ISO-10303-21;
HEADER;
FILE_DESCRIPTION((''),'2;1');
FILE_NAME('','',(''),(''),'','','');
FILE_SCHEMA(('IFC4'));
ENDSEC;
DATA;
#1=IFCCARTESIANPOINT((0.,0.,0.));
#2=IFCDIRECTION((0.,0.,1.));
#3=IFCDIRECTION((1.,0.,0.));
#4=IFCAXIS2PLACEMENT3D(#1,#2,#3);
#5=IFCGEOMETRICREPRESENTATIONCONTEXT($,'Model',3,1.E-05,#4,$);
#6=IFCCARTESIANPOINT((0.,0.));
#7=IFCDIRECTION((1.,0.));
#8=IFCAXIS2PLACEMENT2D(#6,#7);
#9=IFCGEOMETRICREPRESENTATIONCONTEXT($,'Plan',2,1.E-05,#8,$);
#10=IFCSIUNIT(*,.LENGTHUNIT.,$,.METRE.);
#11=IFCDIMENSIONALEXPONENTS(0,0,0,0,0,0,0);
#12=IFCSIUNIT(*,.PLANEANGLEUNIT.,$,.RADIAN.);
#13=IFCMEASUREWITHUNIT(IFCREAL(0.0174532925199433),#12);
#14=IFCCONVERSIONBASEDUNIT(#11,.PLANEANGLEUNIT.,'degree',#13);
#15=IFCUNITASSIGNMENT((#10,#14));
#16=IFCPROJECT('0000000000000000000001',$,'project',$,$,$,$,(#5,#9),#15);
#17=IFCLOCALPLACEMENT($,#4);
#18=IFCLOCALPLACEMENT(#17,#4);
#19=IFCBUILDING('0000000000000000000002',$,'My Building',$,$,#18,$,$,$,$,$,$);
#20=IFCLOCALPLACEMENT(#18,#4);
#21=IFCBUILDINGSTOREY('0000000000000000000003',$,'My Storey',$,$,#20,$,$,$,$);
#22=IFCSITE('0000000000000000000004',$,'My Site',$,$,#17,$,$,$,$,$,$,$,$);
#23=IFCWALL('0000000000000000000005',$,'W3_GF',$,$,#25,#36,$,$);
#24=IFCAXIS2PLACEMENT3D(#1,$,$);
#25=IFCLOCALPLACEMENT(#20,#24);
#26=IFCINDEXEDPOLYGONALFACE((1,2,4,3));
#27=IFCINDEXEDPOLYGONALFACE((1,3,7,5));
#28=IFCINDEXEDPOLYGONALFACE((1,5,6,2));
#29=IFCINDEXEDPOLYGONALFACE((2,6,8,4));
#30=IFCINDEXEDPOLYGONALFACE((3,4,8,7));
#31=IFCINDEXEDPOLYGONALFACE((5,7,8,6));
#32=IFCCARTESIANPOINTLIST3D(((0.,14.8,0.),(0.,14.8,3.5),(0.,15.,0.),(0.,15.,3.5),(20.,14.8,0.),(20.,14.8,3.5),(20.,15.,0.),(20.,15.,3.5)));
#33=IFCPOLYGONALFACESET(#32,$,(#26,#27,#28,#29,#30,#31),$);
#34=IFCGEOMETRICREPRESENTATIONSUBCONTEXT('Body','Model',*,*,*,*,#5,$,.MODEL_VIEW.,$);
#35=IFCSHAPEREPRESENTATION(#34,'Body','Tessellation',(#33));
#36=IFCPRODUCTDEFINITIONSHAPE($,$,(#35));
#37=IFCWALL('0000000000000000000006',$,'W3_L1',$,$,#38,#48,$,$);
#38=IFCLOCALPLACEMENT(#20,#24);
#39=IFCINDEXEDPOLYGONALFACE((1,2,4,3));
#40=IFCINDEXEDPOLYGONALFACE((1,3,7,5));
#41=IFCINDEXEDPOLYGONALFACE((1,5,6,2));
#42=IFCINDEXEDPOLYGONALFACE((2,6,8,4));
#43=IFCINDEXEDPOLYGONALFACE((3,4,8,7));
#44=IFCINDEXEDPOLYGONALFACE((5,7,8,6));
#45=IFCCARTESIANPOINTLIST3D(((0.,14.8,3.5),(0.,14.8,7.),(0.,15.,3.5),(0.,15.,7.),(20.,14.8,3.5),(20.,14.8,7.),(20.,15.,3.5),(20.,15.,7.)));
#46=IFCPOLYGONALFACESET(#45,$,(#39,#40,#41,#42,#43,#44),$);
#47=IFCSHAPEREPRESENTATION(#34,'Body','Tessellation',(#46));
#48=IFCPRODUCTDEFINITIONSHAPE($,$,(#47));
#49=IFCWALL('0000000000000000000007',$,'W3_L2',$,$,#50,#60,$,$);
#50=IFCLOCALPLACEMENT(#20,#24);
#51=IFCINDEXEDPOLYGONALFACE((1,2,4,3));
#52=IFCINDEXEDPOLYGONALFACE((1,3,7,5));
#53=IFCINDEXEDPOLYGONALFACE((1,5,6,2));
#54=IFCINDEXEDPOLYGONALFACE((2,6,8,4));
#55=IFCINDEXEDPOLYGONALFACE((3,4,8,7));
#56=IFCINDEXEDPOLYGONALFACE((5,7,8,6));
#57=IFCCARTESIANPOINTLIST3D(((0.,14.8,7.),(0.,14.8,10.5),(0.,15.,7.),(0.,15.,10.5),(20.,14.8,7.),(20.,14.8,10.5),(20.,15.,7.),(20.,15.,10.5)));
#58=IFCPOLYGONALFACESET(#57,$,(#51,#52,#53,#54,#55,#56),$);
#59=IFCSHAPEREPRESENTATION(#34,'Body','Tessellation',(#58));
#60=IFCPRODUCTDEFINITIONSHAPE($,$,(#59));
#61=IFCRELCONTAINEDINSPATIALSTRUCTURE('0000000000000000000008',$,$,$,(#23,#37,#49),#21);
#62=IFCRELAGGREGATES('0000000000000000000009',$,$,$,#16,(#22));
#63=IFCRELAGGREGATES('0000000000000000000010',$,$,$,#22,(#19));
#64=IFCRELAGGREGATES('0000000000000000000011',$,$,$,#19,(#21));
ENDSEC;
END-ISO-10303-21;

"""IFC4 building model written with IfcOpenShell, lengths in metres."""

from ifc_helpers import new_model, entity, si_unit, converted_unit, frame, origin_with_axes, origin_2d_with_axis, place, context, subcontext, project, spatial, indexed_curve, outline, extrude, element, save


model = new_model("IFC4")

# Units and contexts
model_context = context("Model", 3, precision=1e-05, world=origin_with_axes())
plan_context = context("Plan", 2, precision=1e-05, world=origin_2d_with_axis())
body_context = subcontext(model_context, "Body", "Model", "MODEL_VIEW")
ifc_project = project(units=[si_unit("LENGTHUNIT", "METRE"), converted_unit("PLANEANGLEUNIT", "degree", entity("IfcReal", 0.0174532925199433), si_unit("PLANEANGLEUNIT", "RADIAN"), dimensions=[0, 0, 0, 0, 0, 0, 0])], contexts=[model_context, plan_context])

# Site, building, storey
site_placement = place(None, origin_with_axes())
site = spatial("IfcSite", under=ifc_project, at=site_placement, Name="My Site")
building_placement = place(site_placement, origin_with_axes())
building = spatial("IfcBuilding", under=site, at=building_placement, Name="My Building")
storey_placement = place(building_placement, origin_with_axes())
storey = spatial("IfcBuildingStorey", under=building, at=storey_placement, Name="My Storey")

# Walls
for number, where, z_axis, x_axis, name in (
    (1, (20.0, 15.0, 0.0), (0.0, 0.0, 1.0), (-1.0, 0.0, 0.0), "W3_GF"),
    (2, (20.0, 15.0, 3.5), (0.0, 0.0, 1.0), (-1.0, 0.0, 0.0), "W3_L1"),
    (3, (20.0, 15.0, 7.0), (0.0, 0.0, 1.0), (-1.0, 0.0, 0.0), "W3_L2"),
):
    element("IfcWall", number, at=place(storey_placement, frame(where, z_axis=z_axis, x_axis=x_axis)), inside=storey, Name=name, context=body_context, shape_type="SweptSolid", body=[
        extrude(outline(indexed_curve([(0.0, 0.0), (0.0, 0.2), (20.0, 0.2), (20.0, 0.0), (0.0, 0.0)], self_intersect=False)), origin_with_axes(), (0.0, 0.0, 1.0), 3.5),
    ])

save(model, "model.ifc")
